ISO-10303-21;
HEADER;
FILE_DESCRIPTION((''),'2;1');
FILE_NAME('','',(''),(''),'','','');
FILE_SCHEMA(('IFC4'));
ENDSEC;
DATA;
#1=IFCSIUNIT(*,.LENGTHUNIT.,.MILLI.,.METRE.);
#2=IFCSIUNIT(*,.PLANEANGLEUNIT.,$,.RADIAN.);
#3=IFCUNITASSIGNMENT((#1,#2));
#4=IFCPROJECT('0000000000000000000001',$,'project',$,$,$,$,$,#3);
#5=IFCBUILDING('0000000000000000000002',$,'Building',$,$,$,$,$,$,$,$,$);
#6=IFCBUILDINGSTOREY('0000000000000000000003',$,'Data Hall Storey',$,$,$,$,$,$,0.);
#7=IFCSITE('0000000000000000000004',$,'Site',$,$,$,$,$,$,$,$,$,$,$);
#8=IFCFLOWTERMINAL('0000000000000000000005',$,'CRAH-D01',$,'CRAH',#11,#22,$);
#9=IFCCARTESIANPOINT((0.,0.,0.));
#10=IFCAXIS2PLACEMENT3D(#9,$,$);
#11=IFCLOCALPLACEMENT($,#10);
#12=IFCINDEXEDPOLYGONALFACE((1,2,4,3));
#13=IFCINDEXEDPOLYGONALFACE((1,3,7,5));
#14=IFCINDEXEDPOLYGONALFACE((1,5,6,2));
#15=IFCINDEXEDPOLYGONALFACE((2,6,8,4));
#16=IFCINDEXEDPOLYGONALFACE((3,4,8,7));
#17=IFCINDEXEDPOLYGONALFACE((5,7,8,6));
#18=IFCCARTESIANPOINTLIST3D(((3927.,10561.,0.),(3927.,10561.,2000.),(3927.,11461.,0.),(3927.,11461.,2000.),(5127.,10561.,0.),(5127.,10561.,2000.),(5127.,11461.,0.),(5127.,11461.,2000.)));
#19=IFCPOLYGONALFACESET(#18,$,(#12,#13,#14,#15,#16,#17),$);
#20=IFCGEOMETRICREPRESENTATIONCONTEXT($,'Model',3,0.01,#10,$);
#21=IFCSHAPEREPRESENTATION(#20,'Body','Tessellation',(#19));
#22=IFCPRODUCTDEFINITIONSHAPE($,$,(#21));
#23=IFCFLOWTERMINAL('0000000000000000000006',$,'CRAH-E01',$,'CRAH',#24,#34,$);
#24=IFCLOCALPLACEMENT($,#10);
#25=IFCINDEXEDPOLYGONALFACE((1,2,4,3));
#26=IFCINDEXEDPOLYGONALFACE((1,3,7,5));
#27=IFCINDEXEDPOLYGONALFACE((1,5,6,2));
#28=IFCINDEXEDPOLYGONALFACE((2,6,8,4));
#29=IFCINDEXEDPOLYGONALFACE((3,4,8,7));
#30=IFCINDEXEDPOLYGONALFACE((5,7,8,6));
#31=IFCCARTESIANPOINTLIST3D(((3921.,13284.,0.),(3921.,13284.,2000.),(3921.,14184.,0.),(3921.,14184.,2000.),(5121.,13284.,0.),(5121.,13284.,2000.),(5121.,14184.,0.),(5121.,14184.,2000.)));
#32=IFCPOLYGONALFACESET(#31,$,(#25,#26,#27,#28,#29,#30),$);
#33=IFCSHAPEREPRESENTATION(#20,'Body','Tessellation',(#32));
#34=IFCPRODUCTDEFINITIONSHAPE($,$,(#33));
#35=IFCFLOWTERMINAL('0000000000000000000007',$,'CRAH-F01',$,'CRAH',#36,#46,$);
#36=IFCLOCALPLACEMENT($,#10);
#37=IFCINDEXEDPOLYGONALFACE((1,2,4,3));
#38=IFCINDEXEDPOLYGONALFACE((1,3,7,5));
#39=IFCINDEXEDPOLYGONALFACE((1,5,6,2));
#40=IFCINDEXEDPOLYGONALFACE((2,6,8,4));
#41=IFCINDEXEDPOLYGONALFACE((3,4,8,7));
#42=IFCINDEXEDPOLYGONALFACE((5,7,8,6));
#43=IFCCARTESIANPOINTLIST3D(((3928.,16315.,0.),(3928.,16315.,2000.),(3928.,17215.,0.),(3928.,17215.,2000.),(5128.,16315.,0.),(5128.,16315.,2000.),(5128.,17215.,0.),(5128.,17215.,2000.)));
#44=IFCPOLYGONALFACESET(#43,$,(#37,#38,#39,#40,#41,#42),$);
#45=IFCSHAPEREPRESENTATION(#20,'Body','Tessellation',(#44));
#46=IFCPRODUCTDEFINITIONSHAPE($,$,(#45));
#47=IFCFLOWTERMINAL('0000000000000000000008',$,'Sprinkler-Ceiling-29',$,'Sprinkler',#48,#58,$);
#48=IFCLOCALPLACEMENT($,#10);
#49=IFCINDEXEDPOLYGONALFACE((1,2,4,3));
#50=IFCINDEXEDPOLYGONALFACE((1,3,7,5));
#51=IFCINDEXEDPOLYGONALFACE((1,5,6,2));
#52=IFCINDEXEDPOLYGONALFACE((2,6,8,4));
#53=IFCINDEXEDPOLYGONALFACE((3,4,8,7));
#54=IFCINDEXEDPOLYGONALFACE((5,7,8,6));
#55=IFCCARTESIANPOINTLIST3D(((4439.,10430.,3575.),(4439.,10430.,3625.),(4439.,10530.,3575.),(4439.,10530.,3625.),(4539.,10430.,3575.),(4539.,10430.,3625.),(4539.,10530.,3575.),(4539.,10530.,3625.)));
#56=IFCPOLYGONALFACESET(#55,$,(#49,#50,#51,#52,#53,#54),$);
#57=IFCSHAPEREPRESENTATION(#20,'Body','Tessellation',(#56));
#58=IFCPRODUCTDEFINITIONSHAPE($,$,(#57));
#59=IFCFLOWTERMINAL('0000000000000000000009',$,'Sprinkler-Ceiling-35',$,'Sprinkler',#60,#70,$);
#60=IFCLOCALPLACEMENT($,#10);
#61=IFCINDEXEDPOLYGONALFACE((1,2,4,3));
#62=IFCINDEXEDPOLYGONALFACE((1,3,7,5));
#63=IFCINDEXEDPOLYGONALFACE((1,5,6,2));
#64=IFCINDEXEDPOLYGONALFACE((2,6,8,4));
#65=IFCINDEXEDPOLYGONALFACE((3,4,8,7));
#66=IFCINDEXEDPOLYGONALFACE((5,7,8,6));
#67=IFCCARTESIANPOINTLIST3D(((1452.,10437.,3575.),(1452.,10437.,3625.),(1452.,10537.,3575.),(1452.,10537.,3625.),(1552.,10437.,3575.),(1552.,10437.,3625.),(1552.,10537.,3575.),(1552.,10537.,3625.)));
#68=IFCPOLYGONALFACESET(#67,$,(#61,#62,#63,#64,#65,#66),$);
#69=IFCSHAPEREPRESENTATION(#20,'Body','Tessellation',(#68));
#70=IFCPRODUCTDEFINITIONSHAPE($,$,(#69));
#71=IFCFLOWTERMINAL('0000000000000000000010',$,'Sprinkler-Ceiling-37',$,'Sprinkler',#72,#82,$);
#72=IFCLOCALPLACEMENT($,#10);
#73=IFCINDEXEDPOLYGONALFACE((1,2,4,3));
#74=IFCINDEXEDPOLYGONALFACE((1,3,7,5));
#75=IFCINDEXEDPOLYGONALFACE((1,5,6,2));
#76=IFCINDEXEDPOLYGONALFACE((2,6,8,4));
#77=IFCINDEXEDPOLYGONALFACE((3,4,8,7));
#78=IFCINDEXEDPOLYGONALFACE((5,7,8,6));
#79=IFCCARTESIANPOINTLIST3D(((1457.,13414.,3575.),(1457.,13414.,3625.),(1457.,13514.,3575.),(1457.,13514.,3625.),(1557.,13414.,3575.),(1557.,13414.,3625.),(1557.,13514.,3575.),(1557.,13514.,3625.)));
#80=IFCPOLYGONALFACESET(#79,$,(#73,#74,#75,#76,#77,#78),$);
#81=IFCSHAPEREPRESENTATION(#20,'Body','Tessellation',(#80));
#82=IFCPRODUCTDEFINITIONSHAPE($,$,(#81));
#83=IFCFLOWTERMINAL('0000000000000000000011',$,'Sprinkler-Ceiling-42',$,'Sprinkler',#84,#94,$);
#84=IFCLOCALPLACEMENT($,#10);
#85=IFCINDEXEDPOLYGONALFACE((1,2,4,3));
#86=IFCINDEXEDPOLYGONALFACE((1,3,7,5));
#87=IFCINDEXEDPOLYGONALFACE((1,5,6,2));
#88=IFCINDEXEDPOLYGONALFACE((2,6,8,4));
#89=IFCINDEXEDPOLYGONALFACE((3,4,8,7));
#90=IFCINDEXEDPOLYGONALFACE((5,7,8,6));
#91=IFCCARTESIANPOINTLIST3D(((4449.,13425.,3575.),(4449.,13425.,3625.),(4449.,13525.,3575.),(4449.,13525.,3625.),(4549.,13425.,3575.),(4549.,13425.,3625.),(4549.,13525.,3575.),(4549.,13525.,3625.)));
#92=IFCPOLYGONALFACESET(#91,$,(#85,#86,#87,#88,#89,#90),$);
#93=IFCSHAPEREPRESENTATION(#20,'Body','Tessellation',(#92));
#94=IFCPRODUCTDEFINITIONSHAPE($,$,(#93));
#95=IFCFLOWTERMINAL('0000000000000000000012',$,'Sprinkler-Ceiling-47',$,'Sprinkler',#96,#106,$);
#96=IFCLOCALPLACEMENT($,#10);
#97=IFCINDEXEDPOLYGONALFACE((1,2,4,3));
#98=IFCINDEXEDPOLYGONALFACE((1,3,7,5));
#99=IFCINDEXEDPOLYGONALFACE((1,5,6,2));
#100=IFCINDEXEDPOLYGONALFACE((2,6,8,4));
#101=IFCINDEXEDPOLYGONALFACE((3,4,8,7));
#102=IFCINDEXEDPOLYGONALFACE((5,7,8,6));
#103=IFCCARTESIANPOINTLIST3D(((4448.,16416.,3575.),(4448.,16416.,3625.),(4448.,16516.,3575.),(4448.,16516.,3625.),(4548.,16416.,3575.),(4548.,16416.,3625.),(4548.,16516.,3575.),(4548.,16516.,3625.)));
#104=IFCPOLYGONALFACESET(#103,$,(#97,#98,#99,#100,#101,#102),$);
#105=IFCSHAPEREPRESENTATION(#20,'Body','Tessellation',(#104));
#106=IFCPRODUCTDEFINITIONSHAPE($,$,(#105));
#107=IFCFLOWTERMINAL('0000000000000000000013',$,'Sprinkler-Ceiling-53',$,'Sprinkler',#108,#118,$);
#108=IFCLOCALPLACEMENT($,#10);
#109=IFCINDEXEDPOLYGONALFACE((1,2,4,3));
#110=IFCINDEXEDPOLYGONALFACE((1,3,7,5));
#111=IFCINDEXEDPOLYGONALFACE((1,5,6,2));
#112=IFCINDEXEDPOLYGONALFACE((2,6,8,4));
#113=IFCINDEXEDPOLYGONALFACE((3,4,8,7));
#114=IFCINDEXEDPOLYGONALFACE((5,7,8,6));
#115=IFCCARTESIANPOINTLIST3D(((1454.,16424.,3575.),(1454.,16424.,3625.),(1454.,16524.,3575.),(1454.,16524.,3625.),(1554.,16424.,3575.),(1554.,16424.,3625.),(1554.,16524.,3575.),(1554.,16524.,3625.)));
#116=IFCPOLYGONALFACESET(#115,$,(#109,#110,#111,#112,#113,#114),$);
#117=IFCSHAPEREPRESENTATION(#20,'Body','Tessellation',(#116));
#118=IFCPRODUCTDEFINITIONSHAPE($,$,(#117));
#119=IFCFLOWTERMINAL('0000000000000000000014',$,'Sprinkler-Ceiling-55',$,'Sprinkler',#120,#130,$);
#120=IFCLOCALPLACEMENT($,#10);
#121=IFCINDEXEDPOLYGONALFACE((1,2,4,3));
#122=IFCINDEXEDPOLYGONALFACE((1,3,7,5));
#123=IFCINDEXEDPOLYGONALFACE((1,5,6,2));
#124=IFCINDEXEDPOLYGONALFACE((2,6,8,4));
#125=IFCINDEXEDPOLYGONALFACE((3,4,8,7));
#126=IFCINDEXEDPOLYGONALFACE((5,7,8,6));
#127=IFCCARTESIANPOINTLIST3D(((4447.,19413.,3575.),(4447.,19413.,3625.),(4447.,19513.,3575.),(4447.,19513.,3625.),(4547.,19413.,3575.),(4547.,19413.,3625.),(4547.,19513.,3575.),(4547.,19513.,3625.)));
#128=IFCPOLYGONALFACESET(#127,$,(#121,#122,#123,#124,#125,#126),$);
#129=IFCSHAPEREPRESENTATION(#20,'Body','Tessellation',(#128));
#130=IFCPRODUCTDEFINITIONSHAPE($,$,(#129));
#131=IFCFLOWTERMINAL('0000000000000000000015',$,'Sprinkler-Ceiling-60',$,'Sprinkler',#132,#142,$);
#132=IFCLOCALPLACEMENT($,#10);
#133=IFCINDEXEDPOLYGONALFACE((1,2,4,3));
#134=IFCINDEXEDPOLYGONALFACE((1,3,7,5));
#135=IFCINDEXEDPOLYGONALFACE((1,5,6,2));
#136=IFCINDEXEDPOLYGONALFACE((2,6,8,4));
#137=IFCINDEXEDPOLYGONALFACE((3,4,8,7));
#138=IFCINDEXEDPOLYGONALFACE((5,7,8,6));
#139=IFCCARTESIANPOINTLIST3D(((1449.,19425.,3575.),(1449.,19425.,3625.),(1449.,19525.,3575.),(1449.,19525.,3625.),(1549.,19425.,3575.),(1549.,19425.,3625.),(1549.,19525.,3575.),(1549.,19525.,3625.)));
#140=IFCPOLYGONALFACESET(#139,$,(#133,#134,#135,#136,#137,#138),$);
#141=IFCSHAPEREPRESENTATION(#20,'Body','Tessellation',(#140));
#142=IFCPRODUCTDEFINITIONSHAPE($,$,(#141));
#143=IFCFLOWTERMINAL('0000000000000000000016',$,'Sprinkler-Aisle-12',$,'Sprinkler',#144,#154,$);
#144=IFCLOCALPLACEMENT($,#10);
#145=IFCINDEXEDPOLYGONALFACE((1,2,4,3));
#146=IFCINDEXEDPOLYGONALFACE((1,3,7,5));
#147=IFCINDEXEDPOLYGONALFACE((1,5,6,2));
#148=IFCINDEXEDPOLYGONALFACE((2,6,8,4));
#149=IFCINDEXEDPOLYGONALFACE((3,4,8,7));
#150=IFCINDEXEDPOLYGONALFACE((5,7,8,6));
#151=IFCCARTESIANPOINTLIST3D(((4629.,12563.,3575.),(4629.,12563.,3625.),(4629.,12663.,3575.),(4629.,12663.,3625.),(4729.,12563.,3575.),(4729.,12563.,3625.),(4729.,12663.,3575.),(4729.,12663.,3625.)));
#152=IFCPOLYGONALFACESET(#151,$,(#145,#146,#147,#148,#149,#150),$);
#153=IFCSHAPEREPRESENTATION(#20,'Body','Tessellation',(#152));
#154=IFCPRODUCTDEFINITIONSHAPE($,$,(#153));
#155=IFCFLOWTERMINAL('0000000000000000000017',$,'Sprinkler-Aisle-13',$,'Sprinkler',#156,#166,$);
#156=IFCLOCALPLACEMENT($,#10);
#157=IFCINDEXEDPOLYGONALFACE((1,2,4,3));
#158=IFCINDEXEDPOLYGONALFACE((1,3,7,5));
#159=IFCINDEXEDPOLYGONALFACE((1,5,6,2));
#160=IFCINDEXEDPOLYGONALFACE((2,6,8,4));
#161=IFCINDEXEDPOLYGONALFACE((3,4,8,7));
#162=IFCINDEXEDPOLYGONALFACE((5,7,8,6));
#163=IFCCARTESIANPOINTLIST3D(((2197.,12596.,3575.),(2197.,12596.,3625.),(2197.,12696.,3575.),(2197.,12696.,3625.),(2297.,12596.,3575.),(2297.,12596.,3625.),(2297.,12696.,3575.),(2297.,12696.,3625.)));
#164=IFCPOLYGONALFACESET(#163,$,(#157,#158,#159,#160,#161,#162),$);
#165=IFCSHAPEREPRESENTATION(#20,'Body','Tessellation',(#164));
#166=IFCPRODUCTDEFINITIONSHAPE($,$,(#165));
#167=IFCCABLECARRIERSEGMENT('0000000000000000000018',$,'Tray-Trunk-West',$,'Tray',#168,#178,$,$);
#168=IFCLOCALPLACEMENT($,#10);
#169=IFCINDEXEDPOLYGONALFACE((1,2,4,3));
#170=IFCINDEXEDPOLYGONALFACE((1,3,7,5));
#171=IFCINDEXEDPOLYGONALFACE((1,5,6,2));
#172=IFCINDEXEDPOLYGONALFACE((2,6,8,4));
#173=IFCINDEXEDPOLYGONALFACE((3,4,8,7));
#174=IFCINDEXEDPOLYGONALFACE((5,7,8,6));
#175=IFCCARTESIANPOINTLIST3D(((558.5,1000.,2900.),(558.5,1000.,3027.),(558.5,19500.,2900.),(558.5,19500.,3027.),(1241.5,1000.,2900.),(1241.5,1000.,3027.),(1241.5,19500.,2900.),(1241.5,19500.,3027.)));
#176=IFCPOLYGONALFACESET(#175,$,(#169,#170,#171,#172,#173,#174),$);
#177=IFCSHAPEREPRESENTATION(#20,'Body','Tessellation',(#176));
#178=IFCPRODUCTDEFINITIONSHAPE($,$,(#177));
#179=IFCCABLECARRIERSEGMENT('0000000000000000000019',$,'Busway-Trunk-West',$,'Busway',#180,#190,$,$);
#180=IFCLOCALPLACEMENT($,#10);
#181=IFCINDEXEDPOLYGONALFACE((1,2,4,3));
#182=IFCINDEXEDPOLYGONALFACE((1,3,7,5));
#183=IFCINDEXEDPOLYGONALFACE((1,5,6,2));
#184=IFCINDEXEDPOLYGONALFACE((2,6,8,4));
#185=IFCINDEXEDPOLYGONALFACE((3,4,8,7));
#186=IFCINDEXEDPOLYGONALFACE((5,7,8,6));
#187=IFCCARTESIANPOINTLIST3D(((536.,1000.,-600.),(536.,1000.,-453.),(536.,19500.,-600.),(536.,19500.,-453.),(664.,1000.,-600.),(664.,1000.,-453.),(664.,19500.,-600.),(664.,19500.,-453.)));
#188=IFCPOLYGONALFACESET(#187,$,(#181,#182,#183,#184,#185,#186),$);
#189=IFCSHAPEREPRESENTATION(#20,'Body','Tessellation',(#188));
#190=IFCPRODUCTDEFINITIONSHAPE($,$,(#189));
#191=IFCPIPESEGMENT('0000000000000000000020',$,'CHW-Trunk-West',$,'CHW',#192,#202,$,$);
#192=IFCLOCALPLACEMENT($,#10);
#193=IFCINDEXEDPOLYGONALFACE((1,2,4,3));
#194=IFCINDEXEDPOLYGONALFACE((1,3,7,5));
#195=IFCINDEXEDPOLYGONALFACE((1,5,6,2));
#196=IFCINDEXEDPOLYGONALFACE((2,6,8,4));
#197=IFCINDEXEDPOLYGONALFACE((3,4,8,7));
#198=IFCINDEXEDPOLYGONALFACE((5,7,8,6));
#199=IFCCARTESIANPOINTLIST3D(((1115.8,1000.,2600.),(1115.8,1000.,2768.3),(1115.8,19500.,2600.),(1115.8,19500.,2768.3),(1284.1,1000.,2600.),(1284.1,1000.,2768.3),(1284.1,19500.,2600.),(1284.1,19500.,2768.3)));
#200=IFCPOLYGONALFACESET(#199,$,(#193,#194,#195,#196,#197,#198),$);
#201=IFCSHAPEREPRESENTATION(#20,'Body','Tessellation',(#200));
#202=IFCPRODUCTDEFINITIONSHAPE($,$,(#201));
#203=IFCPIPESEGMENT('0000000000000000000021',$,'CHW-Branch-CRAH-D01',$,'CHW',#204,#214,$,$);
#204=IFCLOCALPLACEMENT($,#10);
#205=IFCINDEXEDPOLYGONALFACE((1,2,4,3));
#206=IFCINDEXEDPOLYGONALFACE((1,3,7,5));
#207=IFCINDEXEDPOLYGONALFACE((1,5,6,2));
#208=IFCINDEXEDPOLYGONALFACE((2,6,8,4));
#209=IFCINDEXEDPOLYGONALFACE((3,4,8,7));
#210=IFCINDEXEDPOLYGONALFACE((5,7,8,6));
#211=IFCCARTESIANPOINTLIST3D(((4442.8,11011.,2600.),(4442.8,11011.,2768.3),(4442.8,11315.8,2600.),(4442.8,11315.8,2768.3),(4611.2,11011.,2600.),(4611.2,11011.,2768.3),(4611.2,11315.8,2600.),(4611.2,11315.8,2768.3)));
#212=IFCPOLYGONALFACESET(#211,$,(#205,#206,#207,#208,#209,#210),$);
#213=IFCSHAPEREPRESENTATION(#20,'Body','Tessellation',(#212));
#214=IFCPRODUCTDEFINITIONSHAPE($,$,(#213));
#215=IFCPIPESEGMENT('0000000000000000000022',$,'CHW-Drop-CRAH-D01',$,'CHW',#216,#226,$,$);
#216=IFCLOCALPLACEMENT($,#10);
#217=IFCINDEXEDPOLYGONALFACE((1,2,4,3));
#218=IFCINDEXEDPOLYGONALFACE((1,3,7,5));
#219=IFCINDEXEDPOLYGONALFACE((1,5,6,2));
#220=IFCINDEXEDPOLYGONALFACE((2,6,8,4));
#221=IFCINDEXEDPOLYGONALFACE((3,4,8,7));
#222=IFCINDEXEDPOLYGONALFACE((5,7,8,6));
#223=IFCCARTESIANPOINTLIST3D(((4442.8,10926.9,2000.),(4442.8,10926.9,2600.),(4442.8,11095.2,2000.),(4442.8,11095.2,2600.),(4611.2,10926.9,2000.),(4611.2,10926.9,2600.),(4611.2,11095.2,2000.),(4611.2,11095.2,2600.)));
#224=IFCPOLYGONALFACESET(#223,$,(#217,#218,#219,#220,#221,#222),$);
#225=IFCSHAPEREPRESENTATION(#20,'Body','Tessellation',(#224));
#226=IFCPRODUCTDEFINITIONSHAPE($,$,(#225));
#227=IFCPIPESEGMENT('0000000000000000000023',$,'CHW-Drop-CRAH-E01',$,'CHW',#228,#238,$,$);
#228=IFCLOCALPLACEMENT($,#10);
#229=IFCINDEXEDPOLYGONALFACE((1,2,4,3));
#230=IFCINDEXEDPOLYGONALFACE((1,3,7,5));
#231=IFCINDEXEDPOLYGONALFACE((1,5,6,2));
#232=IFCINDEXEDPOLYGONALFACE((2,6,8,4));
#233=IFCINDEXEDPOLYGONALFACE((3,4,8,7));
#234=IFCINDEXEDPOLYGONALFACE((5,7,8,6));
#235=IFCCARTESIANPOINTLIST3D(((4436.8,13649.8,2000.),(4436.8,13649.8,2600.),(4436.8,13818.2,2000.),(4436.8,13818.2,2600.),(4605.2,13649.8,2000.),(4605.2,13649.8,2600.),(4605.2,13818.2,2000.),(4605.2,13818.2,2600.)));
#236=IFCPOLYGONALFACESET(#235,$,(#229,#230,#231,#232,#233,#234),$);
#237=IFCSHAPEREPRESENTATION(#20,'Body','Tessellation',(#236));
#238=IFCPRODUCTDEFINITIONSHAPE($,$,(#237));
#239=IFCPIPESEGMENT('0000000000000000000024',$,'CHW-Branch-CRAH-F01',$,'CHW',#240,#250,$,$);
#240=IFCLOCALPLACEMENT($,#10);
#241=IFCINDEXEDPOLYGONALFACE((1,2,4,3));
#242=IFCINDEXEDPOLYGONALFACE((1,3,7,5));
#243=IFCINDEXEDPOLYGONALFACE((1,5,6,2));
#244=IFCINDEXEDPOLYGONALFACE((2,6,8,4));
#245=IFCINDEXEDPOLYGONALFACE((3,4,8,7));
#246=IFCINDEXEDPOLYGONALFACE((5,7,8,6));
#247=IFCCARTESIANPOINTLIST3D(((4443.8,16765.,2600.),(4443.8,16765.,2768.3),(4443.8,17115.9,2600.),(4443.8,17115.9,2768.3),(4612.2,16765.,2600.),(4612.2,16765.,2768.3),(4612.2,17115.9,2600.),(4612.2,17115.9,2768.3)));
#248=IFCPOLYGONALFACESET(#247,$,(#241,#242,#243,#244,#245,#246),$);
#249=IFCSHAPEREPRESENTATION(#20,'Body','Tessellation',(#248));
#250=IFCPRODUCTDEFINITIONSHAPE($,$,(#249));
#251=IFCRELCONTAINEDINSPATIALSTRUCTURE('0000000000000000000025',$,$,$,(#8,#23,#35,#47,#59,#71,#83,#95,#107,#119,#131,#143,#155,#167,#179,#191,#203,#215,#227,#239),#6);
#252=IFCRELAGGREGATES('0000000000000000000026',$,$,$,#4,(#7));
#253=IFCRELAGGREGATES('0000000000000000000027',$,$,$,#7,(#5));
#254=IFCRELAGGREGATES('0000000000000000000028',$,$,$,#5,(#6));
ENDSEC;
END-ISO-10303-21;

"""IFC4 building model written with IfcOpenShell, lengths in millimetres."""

from ifc_helpers import new_model, si_unit, frame, origin, place, context, project, spatial, rectangle, extrude, element, save


model = new_model("IFC4")

# Units and contexts
model_context = context("Model", 3, precision=0.01, world=origin())
ifc_project = project(units=[si_unit("LENGTHUNIT", "METRE", prefix="MILLI"), si_unit("PLANEANGLEUNIT", "RADIAN")])

# Site, building, storey
site = spatial("IfcSite", under=ifc_project, Name="Site")
building = spatial("IfcBuilding", under=site, Name="Building")
storey = spatial("IfcBuildingStorey", under=building, Name="Data Hall Storey", Elevation=0.0)

# Flow terminals
for number, where, name in (
    (1, (4527.0, 11011.0, 0.0), "CRAH-D01"),
    (2, (4521.0, 13734.0, 0.0), "CRAH-E01"),
    (3, (4528.0, 16765.0, 0.0), "CRAH-F01"),
):
    element("IfcFlowTerminal", number, at=place(None, frame(where)), inside=storey, Name=name, ObjectType="CRAH", context=model_context, shape_type="SweptSolid", body=[
        extrude(rectangle(XDim=1200.0, YDim=900.0), origin(), (0.0, 0.0, 1.0), 2000.0),
    ])
for number, where, name in (
    (4, (4489.0, 10480.0, 3575.0), "Sprinkler-Ceiling-29"),
    (5, (1502.0, 10487.0, 3575.0), "Sprinkler-Ceiling-35"),
    (6, (1507.0, 13464.0, 3575.0), "Sprinkler-Ceiling-37"),
    (7, (4499.0, 13475.0, 3575.0), "Sprinkler-Ceiling-42"),
    (8, (4498.0, 16466.0, 3575.0), "Sprinkler-Ceiling-47"),
    (9, (1504.0, 16474.0, 3575.0), "Sprinkler-Ceiling-53"),
    (10, (4497.0, 19463.0, 3575.0), "Sprinkler-Ceiling-55"),
    (11, (1499.0, 19475.0, 3575.0), "Sprinkler-Ceiling-60"),
    (12, (4679.0, 12613.0, 3575.0), "Sprinkler-Aisle-12"),
    (13, (2247.0, 12646.0, 3575.0), "Sprinkler-Aisle-13"),
):
    element("IfcFlowTerminal", number, at=place(None, frame(where)), inside=storey, Name=name, ObjectType="Sprinkler", context=model_context, shape_type="SweptSolid", body=[
        extrude(rectangle(XDim=100.0, YDim=100.0), origin(), (0.0, 0.0, 1.0), 50.0),
    ])

# Cable carrier segments
cable_carrier_segment_1_placement = place(None, frame((900.0, 10250.0, 2900.0)))
element("IfcCableCarrierSegment", 14, at=cable_carrier_segment_1_placement, inside=storey, Name="Tray-Trunk-West", ObjectType="Tray", context=model_context, shape_type="SweptSolid", body=[
    extrude(rectangle(XDim=683.0, YDim=18500.0), origin(), (0.0, 0.0, 1.0), 127.0),
])
cable_carrier_segment_2_placement = place(None, frame((600.0, 10250.0, -600.0)))
element("IfcCableCarrierSegment", 15, at=cable_carrier_segment_2_placement, inside=storey, Name="Busway-Trunk-West", ObjectType="Busway", context=model_context, shape_type="SweptSolid", body=[
    extrude(rectangle(XDim=128.0, YDim=18500.0), origin(), (0.0, 0.0, 1.0), 147.0),
])

# Pipe segments
pipe_segment_1_placement = place(None, frame((1200.0, 10250.0, 2600.0)))
element("IfcPipeSegment", 16, at=pipe_segment_1_placement, inside=storey, Name="CHW-Trunk-West", ObjectType="CHW", context=model_context, shape_type="SweptSolid", body=[
    extrude(rectangle(XDim=168.3, YDim=18500.0), origin(), (0.0, 0.0, 1.0), 168.3),
])
pipe_segment_2_placement = place(None, frame((4527.0, 11163.4, 2600.0)))
element("IfcPipeSegment", 17, at=pipe_segment_2_placement, inside=storey, Name="CHW-Branch-CRAH-D01", ObjectType="CHW", context=model_context, shape_type="SweptSolid", body=[
    extrude(rectangle(XDim=168.3, YDim=304.9), origin(), (0.0, 0.0, 1.0), 168.3),
])
for number, where, name in (
    (18, (4527.0, 11011.0, 2000.0), "CHW-Drop-CRAH-D01"),
    (19, (4521.0, 13734.0, 2000.0), "CHW-Drop-CRAH-E01"),
):
    element("IfcPipeSegment", number, at=place(None, frame(where)), inside=storey, Name=name, ObjectType="CHW", context=model_context, shape_type="SweptSolid", body=[
        extrude(rectangle(XDim=168.3, YDim=168.3), origin(), (0.0, 0.0, 1.0), 600.0),
    ])
pipe_segment_3_placement = place(None, frame((4528.0, 16940.4, 2600.0)))
element("IfcPipeSegment", 20, at=pipe_segment_3_placement, inside=storey, Name="CHW-Branch-CRAH-F01", ObjectType="CHW", context=model_context, shape_type="SweptSolid", body=[
    extrude(rectangle(XDim=168.3, YDim=350.8), origin(), (0.0, 0.0, 1.0), 168.3),
])

save(model, "model.ifc")
